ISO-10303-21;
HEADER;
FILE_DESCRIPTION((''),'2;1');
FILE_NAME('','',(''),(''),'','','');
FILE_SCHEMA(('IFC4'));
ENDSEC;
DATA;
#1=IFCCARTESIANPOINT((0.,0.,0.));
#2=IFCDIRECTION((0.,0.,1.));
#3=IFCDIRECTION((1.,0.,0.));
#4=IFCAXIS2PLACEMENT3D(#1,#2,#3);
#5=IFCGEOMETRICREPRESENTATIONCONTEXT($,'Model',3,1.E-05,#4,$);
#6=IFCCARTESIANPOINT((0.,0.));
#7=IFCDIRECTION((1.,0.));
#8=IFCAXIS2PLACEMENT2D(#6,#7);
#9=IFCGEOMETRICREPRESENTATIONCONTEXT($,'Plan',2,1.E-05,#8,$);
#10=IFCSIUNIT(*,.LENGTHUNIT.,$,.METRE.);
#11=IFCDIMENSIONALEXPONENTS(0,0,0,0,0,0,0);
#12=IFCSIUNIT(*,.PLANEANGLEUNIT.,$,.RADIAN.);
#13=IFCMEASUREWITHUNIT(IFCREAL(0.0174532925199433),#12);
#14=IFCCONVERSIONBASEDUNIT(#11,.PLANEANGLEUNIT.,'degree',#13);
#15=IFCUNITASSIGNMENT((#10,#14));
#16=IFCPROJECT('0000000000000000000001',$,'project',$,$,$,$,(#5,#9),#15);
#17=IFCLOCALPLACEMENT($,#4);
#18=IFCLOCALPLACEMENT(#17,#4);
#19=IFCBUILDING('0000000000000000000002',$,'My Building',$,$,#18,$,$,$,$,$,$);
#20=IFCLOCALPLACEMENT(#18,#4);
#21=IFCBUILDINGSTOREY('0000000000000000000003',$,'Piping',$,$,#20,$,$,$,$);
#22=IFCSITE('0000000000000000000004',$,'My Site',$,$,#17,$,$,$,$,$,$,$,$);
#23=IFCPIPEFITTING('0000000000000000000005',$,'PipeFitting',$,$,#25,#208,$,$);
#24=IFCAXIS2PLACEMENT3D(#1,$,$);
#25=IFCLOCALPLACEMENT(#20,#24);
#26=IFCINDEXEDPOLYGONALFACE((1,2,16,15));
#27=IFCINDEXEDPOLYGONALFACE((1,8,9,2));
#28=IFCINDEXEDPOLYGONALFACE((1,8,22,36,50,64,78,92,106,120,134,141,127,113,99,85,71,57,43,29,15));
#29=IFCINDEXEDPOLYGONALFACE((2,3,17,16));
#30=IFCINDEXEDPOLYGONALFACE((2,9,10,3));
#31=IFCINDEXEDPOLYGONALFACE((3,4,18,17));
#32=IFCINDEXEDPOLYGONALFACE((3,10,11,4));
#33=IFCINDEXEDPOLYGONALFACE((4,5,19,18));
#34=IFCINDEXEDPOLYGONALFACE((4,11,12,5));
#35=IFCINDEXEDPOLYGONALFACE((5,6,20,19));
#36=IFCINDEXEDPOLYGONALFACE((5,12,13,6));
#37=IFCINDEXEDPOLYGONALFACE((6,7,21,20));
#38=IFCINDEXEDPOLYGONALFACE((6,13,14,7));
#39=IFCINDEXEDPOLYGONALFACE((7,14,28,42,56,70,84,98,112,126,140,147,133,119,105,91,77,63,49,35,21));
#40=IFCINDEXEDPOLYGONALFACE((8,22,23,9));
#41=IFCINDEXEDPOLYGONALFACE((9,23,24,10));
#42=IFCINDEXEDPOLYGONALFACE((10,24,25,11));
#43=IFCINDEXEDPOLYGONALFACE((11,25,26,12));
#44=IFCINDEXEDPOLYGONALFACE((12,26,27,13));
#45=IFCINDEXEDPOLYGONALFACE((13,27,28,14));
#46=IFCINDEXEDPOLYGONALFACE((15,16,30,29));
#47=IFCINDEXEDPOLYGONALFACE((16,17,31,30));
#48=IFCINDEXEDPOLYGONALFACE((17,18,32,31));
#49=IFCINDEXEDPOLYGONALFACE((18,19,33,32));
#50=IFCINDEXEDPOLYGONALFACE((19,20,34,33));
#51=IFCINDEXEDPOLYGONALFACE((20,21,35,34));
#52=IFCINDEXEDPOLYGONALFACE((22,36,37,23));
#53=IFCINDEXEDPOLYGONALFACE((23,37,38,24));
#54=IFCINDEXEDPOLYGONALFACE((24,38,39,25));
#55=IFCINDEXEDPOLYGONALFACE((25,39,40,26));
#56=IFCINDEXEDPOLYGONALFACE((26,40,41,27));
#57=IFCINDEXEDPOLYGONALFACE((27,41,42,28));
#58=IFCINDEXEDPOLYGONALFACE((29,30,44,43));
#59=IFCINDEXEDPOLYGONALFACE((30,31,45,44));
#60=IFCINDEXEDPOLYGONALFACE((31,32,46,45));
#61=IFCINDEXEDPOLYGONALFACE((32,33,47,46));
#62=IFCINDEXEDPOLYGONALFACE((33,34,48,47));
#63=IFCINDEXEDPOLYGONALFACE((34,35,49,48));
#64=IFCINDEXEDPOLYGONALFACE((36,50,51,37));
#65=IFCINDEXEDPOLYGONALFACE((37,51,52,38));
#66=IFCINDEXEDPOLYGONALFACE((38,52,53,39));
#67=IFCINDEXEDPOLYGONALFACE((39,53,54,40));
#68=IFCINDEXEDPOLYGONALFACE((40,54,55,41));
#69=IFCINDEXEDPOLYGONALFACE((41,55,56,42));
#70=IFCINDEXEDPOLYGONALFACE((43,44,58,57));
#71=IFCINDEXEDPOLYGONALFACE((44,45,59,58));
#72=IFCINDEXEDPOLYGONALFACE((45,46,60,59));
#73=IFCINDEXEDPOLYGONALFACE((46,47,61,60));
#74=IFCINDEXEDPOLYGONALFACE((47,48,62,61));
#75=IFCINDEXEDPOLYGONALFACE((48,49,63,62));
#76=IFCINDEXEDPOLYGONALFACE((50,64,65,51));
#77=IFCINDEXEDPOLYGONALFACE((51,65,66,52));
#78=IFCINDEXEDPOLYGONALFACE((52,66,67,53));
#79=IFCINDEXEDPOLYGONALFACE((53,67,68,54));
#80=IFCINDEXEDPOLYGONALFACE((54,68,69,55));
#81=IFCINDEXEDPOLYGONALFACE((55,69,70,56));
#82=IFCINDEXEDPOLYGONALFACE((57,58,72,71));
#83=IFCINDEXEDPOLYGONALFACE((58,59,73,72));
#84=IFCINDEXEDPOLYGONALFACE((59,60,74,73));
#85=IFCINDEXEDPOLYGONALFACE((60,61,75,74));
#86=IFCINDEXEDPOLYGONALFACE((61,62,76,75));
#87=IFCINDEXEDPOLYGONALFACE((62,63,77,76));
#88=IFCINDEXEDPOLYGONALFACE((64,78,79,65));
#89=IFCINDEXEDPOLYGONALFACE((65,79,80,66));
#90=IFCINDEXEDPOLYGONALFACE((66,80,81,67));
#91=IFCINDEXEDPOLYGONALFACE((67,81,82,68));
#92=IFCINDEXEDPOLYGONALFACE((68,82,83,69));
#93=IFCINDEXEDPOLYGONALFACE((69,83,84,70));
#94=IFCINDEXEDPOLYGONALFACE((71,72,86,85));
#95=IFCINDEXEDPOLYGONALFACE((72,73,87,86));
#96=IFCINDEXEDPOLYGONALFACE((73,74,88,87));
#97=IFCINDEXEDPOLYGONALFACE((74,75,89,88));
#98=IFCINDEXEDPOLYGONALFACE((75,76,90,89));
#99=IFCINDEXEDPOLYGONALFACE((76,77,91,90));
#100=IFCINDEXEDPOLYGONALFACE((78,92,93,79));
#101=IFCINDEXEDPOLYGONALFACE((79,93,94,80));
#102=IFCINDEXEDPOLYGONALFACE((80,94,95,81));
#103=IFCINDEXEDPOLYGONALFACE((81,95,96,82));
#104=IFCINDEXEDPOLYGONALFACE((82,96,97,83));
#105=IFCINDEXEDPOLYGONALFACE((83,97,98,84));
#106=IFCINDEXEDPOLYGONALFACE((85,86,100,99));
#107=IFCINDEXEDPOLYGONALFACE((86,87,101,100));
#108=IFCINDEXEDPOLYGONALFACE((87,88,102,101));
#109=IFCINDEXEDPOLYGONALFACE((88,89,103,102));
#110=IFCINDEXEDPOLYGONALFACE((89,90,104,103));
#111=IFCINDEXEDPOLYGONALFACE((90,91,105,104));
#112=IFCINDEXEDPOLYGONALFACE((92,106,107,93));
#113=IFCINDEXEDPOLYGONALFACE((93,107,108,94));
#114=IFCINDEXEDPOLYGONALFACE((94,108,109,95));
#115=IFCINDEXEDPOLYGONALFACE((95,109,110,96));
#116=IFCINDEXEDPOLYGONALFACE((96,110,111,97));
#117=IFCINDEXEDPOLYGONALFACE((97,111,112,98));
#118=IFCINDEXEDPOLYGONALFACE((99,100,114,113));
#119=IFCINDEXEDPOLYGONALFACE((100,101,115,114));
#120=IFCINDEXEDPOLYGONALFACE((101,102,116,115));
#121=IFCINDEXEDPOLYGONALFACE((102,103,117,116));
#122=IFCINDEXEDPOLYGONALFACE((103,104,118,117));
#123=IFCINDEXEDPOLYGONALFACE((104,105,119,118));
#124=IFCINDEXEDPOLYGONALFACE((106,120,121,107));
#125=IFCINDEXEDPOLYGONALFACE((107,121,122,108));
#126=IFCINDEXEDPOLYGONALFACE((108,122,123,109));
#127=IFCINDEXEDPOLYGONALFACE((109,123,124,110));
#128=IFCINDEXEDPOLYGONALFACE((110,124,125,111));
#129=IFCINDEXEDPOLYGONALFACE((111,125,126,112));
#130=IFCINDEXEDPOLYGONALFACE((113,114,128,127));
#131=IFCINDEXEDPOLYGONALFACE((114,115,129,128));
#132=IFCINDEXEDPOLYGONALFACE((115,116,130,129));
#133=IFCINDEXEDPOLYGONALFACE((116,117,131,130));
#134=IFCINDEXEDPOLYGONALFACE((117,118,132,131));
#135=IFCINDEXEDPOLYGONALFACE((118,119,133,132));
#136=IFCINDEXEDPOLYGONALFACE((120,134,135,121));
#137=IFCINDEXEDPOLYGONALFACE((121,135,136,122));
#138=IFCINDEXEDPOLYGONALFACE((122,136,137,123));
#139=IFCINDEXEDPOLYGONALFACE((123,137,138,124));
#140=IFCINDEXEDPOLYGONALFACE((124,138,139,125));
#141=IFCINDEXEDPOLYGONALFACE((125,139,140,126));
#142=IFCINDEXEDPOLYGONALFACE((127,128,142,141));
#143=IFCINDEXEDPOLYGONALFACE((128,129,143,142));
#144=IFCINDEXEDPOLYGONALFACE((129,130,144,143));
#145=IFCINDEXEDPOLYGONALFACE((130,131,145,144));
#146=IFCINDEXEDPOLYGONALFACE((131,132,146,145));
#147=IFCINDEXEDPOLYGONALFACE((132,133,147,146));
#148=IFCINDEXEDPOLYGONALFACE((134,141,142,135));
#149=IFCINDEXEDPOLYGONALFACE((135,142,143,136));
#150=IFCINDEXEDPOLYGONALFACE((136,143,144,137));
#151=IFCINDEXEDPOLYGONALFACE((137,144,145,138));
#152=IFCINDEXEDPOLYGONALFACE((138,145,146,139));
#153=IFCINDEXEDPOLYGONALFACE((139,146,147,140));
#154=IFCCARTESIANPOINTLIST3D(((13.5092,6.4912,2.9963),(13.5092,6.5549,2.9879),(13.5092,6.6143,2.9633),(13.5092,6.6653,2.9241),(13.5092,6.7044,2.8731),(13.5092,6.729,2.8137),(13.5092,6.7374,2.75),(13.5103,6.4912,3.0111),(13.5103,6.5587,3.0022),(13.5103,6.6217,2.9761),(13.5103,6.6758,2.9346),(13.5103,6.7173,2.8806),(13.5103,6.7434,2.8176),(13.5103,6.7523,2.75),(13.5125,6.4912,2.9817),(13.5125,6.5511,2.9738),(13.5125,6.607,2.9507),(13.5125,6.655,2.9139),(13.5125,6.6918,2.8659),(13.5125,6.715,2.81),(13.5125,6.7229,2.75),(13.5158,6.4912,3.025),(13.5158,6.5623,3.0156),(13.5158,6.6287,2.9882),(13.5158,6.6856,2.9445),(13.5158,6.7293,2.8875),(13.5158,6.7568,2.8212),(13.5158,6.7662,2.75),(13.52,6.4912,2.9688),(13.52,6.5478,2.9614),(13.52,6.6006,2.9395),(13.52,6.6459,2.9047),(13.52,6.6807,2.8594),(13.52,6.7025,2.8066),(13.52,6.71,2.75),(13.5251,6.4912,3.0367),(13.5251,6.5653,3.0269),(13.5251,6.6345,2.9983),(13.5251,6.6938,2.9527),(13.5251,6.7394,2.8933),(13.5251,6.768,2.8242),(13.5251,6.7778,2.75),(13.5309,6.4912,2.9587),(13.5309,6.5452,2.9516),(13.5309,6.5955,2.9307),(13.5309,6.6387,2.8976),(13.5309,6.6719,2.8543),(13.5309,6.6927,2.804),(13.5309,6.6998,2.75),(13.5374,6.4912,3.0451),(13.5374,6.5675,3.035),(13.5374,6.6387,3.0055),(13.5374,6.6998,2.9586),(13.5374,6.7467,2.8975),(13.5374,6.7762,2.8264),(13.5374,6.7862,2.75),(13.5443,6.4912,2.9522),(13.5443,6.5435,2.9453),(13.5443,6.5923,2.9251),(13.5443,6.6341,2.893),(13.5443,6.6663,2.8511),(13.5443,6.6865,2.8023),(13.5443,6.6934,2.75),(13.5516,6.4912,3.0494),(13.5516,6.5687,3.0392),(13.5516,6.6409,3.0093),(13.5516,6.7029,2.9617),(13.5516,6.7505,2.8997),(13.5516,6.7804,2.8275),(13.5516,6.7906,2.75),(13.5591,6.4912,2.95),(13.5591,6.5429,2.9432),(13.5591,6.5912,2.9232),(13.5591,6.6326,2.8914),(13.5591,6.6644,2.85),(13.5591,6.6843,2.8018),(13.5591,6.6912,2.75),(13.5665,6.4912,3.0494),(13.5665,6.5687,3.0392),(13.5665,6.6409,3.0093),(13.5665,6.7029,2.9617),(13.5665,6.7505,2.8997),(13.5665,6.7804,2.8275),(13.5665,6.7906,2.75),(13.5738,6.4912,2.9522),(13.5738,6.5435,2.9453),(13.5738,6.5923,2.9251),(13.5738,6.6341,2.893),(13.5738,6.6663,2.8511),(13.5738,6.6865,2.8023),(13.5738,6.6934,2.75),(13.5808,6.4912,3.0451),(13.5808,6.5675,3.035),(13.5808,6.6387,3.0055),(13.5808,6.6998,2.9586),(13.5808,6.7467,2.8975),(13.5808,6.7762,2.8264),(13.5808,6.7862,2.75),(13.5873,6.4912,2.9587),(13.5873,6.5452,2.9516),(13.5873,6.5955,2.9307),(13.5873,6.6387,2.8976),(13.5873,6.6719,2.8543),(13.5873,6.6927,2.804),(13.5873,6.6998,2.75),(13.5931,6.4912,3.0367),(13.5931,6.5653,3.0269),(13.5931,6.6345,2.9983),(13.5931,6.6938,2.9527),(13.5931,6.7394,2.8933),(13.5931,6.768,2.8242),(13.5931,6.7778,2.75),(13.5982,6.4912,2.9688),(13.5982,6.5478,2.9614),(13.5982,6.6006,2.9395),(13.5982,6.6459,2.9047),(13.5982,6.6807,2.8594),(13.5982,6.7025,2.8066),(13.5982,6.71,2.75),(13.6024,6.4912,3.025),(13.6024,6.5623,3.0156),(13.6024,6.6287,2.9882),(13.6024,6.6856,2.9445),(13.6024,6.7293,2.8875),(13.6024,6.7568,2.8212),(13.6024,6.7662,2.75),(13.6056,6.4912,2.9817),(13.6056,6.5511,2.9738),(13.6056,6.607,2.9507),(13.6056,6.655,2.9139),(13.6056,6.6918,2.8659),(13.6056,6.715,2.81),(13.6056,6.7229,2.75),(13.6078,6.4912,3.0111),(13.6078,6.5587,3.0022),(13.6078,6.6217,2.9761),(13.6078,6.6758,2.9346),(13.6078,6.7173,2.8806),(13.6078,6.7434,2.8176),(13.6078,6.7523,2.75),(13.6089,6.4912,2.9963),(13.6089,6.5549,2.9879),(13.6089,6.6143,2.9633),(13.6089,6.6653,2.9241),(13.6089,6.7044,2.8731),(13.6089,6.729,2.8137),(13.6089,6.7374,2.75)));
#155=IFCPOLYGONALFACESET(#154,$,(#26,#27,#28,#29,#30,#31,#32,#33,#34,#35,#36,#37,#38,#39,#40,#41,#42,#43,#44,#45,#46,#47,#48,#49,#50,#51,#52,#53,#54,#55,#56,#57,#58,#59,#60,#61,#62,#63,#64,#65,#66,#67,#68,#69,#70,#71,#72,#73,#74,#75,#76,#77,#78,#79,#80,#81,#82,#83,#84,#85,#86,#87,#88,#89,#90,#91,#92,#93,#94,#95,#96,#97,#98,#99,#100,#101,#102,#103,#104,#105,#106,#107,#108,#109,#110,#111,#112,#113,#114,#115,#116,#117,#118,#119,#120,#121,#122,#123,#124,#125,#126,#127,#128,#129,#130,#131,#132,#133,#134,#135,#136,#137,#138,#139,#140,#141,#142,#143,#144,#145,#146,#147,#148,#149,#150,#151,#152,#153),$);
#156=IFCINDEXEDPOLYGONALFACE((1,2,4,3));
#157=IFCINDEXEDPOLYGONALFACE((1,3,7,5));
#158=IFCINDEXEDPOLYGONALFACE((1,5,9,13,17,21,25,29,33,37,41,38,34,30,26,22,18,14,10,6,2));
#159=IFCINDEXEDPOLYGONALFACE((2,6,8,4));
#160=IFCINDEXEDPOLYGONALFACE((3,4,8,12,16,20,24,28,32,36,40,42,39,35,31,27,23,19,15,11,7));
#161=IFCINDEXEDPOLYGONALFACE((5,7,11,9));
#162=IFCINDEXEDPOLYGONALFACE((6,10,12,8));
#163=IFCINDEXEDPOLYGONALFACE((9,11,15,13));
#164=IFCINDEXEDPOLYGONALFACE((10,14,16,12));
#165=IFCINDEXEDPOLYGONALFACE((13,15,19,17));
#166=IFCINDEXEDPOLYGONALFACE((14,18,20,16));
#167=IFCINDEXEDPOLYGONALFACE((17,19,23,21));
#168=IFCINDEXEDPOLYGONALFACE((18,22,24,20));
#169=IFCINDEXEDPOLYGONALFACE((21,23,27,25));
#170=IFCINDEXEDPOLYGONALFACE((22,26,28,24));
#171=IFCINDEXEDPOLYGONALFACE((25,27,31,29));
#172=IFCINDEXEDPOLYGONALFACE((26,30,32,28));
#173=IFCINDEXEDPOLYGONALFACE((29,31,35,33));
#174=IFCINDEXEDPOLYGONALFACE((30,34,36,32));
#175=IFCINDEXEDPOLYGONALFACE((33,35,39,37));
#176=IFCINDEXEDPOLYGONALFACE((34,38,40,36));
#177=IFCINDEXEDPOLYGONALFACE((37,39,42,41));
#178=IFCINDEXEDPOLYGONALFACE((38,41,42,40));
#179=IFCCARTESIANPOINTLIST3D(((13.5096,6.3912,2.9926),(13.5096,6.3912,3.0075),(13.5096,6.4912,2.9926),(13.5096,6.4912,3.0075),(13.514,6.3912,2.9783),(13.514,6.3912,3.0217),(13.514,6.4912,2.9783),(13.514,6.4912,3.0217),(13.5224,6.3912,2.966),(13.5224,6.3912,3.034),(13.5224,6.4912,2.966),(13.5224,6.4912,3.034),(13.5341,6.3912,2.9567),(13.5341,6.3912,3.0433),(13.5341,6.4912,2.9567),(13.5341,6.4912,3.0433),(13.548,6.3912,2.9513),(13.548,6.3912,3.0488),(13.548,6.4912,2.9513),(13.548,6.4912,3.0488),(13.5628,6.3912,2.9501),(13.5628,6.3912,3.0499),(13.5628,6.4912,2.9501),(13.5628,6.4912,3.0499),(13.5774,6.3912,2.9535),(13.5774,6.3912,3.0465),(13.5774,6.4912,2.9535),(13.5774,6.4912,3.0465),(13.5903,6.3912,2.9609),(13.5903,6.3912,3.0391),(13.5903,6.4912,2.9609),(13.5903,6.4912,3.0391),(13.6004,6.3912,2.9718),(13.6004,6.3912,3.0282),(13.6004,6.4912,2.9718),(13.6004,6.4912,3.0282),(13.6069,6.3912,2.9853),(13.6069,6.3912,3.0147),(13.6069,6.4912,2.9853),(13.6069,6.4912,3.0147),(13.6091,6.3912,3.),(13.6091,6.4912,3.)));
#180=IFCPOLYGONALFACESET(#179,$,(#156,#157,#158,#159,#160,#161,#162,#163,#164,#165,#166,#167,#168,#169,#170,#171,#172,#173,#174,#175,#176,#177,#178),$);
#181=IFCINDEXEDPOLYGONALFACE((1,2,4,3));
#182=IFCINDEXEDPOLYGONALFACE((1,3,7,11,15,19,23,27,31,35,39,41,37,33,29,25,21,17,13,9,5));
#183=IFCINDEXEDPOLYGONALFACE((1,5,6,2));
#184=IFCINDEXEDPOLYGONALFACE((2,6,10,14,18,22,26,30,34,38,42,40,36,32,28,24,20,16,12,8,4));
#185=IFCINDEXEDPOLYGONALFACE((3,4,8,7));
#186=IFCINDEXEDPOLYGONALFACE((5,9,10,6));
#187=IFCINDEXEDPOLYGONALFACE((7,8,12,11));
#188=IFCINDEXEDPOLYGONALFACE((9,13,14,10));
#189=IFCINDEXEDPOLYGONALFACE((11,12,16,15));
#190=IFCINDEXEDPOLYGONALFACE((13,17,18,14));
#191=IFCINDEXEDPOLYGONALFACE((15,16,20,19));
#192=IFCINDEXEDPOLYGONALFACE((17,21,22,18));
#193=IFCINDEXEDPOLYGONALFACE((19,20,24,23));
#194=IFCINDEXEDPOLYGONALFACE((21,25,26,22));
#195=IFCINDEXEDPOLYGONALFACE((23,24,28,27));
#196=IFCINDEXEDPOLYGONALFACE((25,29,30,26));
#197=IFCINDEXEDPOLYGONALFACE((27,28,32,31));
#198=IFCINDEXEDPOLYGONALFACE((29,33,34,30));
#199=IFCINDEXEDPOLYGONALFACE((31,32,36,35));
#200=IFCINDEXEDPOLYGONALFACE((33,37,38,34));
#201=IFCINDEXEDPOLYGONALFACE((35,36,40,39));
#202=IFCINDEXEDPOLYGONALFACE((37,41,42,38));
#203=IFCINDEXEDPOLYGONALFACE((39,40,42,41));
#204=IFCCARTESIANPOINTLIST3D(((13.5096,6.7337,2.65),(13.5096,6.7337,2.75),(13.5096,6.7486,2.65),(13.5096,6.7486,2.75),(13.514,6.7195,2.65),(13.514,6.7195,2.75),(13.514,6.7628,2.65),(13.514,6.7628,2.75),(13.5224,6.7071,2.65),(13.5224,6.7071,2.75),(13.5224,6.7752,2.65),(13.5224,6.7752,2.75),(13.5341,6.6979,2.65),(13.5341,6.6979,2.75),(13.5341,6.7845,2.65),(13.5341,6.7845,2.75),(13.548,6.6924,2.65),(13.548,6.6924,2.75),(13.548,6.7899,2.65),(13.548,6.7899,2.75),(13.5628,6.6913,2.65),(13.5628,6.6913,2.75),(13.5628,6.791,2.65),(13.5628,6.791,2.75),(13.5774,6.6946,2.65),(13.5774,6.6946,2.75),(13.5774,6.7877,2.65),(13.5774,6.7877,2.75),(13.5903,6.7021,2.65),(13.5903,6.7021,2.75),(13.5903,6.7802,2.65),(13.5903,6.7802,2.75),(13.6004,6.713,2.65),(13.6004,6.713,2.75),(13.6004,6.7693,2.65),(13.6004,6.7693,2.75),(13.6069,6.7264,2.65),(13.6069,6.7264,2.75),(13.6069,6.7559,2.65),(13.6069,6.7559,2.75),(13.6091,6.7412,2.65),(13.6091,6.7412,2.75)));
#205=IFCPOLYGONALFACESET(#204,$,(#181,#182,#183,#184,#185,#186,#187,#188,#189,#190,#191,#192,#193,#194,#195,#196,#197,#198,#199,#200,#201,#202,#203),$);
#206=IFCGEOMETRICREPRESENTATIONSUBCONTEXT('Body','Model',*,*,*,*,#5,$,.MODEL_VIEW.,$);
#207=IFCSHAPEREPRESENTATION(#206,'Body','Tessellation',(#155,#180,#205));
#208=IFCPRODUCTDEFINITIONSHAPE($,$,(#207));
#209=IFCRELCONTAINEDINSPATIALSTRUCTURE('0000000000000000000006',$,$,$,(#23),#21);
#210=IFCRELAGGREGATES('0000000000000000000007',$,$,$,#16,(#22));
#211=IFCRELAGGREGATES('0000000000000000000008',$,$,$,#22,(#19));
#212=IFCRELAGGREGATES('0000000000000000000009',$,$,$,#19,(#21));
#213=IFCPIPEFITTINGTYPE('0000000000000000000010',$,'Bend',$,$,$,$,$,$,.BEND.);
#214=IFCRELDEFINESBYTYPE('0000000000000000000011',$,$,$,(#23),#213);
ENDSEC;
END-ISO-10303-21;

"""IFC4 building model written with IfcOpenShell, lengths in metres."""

from ifc_helpers import new_model, entity, si_unit, converted_unit, frame, origin_with_axes, origin_2d_with_axis, place, context, subcontext, project, spatial, circle, extrude, source, transform, mapped, type_object, type_shapes, element, save


model = new_model("IFC4")

# Units and contexts
model_context = context("Model", 3, precision=1e-05, world=origin_with_axes())
plan_context = context("Plan", 2, precision=1e-05, world=origin_2d_with_axis())
body_context = subcontext(model_context, "Body", "Model", "MODEL_VIEW")
ifc_project = project(units=[si_unit("LENGTHUNIT", "METRE"), converted_unit("PLANEANGLEUNIT", "degree", entity("IfcReal", 0.0174532925199433), si_unit("PLANEANGLEUNIT", "RADIAN"), dimensions=[0, 0, 0, 0, 0, 0, 0])], contexts=[model_context, plan_context])

# Site, building, storey
site_placement = place(None, origin_with_axes())
site = spatial("IfcSite", under=ifc_project, at=site_placement, Name="My Site")
building_placement = place(site_placement, origin_with_axes())
building = spatial("IfcBuilding", under=site, at=building_placement, Name="My Building")
storey_placement = place(building_placement, origin_with_axes())
storey = spatial("IfcBuildingStorey", under=building, at=storey_placement, Name="Piping")

# Pipe fitting
pipe_fitting_type = type_object("IfcPipeFittingType", Name="Bend", PredefinedType="BEND")
shared_shape = source(origin_with_axes(), body_context, "Body", "SolidModel", [
    entity("IfcSweptDiskSolid", entity("IfcIndexedPolyCurve", entity("IfcCartesianPointList3D", [[0.0, 0.0, -0.1], [0.0, -0.0732, -0.2768], [0.0, -0.25, -0.35]]), [entity("IfcArcIndex", [1, 2, 3])]), 0.05),
    extrude(circle(Radius=0.05), origin_with_axes(), (0.0, 0.0, -1.0), 0.1),
    extrude(circle(Radius=0.05), frame((0.0, -0.25, -0.35), z_axis=(0.0, -1.0, 0.0), x_axis=(1.0, 0.0, 0.0)), (0.0, 0.0, 1.0), 0.1),
])
type_shapes(pipe_fitting_type, [shared_shape])
for number, where, z_axis, x_axis, name in (
    (1, (13.5591, 6.3912, 3.0), (0.0, -1.0, 0.0), (1.0, 0.0, 0.0), "PipeFitting"),
):
    element("IfcPipeFitting", number, at=place(storey_placement, frame(where, z_axis=z_axis, x_axis=x_axis)), inside=storey, type_object=pipe_fitting_type, Name=name, context=body_context, shape_type="MappedRepresentation", body=[
        mapped(shared_shape, transform((0.0, 0.0, 0.0), x_axis=(1.0, 0.0, 0.0), y_axis=(0.0, 1.0, 0.0), z_axis=(0.0, 0.0, 1.0), scale=1.0)),
    ])

save(model, "model.ifc")
